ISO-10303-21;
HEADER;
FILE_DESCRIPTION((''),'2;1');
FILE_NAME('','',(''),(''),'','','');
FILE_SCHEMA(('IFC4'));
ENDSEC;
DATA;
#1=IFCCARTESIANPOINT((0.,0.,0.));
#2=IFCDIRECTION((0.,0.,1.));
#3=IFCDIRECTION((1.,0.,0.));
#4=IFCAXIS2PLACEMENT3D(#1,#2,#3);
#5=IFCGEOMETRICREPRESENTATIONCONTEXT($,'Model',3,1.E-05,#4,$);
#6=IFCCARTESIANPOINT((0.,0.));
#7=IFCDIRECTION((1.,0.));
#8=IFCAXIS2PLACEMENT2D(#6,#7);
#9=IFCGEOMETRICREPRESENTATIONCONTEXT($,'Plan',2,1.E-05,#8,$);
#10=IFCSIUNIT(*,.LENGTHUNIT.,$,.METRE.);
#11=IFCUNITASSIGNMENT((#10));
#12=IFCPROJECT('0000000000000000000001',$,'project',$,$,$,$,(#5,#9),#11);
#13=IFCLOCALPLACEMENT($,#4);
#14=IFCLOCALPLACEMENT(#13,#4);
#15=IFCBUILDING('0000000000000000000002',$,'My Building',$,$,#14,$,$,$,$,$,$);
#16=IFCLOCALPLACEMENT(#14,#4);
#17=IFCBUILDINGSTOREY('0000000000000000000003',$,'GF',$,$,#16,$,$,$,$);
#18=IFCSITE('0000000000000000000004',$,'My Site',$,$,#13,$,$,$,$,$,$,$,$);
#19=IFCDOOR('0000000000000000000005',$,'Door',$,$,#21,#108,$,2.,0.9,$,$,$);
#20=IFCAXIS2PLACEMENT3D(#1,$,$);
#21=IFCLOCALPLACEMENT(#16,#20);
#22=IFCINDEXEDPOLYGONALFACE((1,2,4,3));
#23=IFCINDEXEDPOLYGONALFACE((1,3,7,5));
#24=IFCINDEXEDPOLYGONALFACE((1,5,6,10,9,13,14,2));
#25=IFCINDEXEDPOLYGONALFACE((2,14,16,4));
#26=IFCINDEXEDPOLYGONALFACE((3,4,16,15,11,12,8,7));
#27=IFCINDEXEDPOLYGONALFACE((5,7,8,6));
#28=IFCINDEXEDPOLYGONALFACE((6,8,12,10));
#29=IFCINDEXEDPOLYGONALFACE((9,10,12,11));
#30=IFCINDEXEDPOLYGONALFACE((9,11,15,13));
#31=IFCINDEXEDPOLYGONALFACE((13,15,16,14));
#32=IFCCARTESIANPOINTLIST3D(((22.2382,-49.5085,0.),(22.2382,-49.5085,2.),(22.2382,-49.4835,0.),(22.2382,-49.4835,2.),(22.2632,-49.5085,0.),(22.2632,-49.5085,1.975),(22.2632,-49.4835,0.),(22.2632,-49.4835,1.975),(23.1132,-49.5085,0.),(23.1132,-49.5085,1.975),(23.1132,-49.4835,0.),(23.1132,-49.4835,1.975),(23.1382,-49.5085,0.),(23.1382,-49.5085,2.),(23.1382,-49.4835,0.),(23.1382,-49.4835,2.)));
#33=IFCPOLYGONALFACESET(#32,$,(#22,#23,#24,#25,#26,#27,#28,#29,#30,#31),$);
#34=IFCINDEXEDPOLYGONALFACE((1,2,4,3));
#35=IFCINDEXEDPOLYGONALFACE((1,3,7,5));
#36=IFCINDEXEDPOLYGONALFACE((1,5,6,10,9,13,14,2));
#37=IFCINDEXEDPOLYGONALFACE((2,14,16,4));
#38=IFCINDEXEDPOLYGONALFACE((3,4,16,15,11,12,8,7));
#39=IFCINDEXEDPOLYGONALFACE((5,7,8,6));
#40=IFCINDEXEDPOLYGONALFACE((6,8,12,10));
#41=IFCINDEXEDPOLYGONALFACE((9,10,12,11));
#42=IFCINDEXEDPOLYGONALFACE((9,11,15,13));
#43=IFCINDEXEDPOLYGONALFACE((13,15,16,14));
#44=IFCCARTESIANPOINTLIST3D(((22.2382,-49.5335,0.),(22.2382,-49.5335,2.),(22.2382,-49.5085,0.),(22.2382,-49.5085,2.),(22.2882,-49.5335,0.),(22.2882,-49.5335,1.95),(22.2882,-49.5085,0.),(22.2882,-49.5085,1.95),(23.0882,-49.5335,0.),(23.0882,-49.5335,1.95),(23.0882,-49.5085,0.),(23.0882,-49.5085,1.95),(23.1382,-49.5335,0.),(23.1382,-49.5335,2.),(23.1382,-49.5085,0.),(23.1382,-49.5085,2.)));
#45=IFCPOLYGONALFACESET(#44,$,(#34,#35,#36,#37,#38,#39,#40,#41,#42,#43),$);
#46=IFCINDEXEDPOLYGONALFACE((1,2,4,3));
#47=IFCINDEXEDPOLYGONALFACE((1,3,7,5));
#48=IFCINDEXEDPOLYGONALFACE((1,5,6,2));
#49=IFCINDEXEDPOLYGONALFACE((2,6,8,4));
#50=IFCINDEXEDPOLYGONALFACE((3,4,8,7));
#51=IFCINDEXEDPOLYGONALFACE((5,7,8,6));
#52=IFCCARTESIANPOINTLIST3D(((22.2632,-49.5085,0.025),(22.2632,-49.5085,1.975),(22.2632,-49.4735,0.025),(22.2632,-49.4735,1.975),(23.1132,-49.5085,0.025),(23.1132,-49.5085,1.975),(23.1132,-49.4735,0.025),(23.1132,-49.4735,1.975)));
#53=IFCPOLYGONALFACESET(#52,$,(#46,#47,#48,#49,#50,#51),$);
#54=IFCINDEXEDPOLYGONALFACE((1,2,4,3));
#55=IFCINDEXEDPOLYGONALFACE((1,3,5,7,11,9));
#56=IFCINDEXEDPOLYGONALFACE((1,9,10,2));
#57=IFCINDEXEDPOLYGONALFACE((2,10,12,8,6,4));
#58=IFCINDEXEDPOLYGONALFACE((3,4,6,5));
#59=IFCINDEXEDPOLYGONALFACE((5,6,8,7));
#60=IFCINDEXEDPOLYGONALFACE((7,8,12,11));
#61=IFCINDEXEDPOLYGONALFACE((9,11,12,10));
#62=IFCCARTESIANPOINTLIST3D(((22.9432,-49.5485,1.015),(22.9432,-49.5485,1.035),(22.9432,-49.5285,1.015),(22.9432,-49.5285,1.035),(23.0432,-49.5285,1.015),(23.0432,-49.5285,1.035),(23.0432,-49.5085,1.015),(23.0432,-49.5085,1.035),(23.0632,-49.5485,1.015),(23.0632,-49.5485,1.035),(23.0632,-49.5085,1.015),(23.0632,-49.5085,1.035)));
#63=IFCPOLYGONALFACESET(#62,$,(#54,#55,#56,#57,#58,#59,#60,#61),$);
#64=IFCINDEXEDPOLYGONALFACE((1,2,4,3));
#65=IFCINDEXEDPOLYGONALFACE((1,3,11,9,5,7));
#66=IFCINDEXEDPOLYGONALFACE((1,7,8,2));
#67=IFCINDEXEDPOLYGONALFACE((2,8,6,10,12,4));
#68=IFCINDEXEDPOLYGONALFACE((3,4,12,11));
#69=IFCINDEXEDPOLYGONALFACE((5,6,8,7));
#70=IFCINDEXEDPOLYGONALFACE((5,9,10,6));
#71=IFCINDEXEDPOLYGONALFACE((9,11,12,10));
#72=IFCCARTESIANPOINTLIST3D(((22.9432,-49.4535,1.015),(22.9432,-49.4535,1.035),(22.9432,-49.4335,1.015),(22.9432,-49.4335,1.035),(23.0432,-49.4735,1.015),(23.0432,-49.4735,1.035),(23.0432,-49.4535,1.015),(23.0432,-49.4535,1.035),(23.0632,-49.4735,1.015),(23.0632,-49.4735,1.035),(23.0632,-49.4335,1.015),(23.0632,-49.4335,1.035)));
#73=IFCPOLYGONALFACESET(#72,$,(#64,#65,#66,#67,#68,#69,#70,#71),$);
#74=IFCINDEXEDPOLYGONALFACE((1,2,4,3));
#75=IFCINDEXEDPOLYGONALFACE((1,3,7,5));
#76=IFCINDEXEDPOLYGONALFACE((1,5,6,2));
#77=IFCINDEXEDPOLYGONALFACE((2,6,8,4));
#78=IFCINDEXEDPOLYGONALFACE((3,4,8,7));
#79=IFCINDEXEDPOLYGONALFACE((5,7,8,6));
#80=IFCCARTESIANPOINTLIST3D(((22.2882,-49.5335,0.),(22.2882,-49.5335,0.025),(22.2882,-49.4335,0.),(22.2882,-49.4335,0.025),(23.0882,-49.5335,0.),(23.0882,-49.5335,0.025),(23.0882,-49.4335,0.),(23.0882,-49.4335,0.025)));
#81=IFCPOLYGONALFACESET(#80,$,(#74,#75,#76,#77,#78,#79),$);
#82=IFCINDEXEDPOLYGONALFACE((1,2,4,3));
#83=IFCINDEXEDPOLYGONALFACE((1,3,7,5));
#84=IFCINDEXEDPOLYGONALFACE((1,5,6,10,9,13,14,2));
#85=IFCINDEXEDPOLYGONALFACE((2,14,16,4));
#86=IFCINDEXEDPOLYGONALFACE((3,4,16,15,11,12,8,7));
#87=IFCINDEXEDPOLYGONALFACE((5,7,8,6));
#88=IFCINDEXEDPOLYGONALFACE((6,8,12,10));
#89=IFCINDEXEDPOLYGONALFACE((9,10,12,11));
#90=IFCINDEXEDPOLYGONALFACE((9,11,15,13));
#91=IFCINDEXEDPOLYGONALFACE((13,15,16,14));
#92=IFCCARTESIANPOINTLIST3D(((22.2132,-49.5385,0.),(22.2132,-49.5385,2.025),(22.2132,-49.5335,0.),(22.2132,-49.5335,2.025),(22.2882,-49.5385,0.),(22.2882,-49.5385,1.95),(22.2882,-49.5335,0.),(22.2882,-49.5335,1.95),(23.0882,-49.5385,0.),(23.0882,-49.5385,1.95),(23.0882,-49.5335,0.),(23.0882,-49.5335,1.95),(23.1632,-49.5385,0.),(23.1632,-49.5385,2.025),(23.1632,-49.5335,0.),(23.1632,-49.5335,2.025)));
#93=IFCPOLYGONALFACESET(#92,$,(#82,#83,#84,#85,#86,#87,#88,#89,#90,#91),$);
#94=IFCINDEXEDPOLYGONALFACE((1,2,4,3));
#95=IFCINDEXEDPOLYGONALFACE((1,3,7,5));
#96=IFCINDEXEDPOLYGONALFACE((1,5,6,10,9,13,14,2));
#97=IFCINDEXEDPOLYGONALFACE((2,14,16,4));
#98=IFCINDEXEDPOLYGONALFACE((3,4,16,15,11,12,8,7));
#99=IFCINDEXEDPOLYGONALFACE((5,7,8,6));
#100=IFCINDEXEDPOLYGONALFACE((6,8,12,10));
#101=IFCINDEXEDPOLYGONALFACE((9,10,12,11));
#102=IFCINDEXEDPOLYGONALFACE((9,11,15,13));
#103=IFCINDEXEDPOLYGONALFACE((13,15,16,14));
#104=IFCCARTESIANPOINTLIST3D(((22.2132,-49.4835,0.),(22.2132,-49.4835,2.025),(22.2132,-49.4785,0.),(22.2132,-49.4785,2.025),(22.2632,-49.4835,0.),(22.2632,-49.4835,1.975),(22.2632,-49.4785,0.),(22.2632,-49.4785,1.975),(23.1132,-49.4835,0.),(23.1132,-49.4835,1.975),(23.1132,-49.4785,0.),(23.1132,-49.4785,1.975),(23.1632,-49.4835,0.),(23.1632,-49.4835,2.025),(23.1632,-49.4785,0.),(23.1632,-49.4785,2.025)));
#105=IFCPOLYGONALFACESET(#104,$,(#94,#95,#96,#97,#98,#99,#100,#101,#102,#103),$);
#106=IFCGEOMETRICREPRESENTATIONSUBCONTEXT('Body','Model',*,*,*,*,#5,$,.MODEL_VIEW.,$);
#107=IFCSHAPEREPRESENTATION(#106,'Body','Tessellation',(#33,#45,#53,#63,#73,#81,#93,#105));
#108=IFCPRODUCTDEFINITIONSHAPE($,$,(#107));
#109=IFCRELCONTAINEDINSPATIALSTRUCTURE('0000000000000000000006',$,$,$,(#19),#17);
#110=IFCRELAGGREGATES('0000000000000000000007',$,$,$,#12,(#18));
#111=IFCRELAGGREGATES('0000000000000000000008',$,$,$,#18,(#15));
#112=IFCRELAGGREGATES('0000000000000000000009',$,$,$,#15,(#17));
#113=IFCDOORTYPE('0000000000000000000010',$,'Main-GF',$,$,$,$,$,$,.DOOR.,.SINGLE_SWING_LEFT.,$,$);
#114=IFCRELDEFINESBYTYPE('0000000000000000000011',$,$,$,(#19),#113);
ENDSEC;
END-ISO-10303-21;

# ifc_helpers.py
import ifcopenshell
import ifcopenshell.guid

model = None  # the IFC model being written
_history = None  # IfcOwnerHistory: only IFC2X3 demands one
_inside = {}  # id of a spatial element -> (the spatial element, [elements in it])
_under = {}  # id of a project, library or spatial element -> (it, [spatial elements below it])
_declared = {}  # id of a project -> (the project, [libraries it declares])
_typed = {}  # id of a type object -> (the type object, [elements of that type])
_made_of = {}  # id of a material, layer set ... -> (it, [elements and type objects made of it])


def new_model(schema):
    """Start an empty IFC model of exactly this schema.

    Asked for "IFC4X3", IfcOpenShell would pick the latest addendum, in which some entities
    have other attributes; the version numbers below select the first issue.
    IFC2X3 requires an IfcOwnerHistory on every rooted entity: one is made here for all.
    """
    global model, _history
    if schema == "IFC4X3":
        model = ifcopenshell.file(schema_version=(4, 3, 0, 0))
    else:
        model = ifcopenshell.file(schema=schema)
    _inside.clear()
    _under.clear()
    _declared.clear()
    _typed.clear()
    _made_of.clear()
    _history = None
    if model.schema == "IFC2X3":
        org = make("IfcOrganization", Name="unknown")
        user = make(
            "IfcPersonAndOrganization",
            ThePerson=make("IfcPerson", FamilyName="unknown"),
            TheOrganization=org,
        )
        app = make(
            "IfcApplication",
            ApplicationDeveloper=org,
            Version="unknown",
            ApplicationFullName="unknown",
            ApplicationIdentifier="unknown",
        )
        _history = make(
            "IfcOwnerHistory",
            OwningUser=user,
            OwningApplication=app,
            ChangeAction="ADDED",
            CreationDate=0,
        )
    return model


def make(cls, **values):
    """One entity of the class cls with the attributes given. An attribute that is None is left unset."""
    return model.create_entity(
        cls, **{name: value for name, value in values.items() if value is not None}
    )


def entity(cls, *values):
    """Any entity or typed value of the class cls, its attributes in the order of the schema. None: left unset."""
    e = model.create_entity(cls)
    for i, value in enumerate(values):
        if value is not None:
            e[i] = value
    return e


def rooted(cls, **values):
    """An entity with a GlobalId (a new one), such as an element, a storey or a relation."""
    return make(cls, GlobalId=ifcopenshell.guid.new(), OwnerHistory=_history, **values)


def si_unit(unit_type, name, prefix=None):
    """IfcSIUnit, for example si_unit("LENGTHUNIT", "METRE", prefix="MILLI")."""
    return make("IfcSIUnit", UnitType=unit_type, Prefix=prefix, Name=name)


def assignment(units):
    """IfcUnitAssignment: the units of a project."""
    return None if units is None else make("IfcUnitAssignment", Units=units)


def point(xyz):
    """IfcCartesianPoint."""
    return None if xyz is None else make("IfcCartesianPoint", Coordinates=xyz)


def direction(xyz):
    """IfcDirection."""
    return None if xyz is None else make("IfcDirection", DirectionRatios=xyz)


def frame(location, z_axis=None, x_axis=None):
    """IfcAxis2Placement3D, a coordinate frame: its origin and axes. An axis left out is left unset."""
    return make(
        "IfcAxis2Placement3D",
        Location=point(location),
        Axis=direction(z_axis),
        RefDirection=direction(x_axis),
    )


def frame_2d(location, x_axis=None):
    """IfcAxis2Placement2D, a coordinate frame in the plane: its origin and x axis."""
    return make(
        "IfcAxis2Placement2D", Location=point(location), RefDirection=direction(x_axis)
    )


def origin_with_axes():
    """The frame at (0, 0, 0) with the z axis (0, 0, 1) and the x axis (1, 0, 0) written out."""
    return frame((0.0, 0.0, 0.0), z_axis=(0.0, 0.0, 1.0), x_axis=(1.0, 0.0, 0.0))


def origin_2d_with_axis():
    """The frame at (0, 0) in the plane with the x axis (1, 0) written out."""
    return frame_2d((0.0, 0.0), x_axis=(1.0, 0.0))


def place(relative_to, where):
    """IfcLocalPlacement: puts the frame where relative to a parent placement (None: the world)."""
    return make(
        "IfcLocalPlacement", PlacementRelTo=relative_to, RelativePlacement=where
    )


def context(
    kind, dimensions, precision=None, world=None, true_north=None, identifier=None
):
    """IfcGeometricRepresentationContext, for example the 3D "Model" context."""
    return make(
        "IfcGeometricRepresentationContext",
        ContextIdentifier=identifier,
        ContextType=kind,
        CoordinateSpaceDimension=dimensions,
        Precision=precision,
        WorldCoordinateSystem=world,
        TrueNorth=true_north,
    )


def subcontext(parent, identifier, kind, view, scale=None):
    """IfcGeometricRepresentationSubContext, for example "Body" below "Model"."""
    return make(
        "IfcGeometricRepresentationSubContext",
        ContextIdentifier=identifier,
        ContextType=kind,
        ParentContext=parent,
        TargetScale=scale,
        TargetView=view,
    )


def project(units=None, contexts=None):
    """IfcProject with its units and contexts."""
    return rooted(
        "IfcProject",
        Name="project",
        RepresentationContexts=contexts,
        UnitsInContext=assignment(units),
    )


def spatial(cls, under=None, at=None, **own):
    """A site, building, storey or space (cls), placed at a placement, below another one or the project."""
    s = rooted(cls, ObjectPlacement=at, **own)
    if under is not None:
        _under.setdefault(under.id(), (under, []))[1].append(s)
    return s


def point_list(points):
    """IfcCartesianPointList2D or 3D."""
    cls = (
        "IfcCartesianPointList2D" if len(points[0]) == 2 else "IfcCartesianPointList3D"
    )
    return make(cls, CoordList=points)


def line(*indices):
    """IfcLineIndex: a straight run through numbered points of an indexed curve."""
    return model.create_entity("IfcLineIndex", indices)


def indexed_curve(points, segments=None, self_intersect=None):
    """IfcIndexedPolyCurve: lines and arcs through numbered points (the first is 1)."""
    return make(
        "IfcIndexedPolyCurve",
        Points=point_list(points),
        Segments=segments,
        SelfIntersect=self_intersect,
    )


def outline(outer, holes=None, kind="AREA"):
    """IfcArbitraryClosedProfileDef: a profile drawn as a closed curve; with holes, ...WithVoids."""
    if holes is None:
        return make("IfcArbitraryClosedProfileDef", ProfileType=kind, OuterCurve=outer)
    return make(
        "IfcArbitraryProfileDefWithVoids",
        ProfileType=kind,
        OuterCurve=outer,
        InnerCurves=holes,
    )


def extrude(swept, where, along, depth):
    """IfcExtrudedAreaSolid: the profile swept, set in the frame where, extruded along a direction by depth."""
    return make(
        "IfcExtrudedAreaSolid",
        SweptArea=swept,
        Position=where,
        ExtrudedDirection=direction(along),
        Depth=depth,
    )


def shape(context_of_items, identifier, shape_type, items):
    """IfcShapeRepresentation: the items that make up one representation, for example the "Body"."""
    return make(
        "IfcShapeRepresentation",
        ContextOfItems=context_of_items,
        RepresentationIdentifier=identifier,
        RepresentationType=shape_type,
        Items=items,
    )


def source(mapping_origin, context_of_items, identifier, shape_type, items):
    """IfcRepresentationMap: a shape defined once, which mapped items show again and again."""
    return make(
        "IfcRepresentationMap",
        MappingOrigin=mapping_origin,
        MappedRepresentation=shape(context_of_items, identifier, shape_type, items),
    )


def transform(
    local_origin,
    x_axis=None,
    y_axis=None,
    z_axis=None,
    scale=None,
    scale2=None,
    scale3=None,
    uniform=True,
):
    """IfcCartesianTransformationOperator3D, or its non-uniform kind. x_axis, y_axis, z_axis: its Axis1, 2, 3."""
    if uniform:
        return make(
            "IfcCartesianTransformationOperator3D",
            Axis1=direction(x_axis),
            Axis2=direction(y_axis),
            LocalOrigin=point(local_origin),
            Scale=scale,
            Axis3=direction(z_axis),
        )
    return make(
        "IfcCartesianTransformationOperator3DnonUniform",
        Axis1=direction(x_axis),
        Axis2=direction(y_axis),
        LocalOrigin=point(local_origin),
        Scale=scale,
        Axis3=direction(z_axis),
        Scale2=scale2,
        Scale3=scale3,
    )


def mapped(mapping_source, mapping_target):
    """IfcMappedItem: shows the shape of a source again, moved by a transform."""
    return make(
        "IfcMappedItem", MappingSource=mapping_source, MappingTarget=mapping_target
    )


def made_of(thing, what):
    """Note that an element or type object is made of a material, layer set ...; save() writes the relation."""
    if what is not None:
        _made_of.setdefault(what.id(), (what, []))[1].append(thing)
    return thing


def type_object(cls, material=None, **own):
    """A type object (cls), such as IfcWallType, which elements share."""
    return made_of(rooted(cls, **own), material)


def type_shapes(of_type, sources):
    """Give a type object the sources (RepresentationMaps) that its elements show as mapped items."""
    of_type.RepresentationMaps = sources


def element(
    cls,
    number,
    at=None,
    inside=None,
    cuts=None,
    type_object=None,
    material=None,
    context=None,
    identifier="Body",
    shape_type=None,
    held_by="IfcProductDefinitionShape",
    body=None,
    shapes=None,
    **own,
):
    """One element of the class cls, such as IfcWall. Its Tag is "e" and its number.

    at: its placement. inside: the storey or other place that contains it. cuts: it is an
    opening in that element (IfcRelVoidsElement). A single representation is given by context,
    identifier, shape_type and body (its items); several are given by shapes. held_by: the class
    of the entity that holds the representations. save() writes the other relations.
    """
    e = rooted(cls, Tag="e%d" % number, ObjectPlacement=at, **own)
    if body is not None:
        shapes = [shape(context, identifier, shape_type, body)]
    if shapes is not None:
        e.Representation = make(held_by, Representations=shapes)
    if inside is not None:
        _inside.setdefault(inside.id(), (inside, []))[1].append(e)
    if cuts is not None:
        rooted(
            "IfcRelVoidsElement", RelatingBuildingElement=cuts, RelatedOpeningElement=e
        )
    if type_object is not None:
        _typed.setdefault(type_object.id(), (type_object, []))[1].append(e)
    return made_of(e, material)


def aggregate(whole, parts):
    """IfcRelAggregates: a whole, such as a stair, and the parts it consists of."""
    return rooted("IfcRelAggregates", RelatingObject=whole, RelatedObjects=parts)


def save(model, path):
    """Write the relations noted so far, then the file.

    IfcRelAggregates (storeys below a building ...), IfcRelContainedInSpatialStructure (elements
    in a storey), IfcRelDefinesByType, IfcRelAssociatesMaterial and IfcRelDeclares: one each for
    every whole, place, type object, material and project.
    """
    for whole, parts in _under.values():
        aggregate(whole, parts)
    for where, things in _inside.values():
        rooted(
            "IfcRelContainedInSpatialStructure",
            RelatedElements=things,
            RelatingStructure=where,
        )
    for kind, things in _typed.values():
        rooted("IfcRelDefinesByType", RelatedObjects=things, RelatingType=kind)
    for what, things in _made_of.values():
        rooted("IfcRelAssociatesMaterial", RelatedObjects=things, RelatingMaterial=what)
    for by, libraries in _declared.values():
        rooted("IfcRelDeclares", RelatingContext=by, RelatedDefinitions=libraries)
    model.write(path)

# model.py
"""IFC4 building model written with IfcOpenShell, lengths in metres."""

from ifc_helpers import new_model, entity, si_unit, frame, origin_with_axes, origin_2d_with_axis, place, context, subcontext, project, spatial, line, indexed_curve, outline, extrude, shape, source, transform, mapped, type_object, type_shapes, element, save


model = new_model("IFC4")

# Units and contexts
model_context = context("Model", 3, precision=1e-05, world=origin_with_axes())
plan_context = context("Plan", 2, precision=1e-05, world=origin_2d_with_axis())
body_context_1 = subcontext(model_context, "Body", "Model", "MODEL_VIEW")
body_context_2 = subcontext(plan_context, "Body", "Plan", "PLAN_VIEW")
ifc_project = project(units=[si_unit("LENGTHUNIT", "METRE")], contexts=[model_context, plan_context])

# Site, building, storey
site_placement = place(None, origin_with_axes())
site = spatial("IfcSite", under=ifc_project, at=site_placement, Name="My Site")
building_placement = place(site_placement, origin_with_axes())
building = spatial("IfcBuilding", under=site, at=building_placement, Name="My Building")
storey_placement = place(building_placement, origin_with_axes())
storey = spatial("IfcBuildingStorey", under=building, at=storey_placement, Name="GF")

# Shared definitions
door_type_1 = type_object("IfcDoorType", Name="Main-GF", OperationType="SINGLE_SWING_LEFT", PredefinedType="DOOR")
shared_shape_1 = source(origin_with_axes(), body_context_1, "Body", "SweptSolid", [
    extrude(outline(indexed_curve([(0.0, 0.0), (0.0, 2.0), (0.9, 2.0), (0.9, 0.0), (0.875, 0.0), (0.875, 1.975), (0.025, 1.975), (0.025, 0.0)], segments=[line(1, 2, 3, 4, 5, 6, 7, 8, 1)])), frame((0.0, 0.025, 0.0), z_axis=(0.0, -1.0, 0.0), x_axis=(1.0, 0.0, 0.0)), (0.0, 0.0, -1.0), 0.025),
    extrude(outline(indexed_curve([(0.0, 0.0), (0.0, 2.0), (0.9, 2.0), (0.9, 0.0), (0.85, 0.0), (0.85, 1.95), (0.05, 1.95), (0.05, 0.0)], segments=[line(1, 2, 3, 4, 5, 6, 7, 8, 1)])), frame((0.0, 0.0, 0.0), z_axis=(0.0, -1.0, 0.0), x_axis=(1.0, 0.0, 0.0)), (0.0, 0.0, -1.0), 0.025),
    extrude(outline(indexed_curve([(0.0, 0.0), (0.85, 0.0), (0.85, 0.035), (0.0, 0.035)], segments=[line(1, 2, 3, 4, 1)])), frame((0.025, 0.025, 0.025), z_axis=(0.0, 0.0, 1.0), x_axis=(1.0, 0.0, 0.0)), (0.0, 0.0, 1.0), 1.95),
    extrude(outline(indexed_curve([(0.0, 0.0), (0.0, -0.04), (-0.12, -0.04), (-0.12, -0.02), (-0.02, -0.02), (-0.02, 0.0)], segments=[line(1, 2, 3, 4, 5, 6, 1)])), frame((0.825, 0.025, 1.015), z_axis=(0.0, 0.0, 1.0), x_axis=(1.0, 0.0, 0.0)), (0.0, 0.0, 1.0), 0.02),
    extrude(outline(indexed_curve([(0.0, 0.0), (0.0, 0.04), (-0.12, 0.04), (-0.12, 0.02), (-0.02, 0.02), (-0.02, 0.0)], segments=[line(1, 2, 3, 4, 5, 6, 1)])), frame((0.825, 0.06, 1.015), z_axis=(0.0, 0.0, 1.0), x_axis=(1.0, 0.0, 0.0)), (0.0, 0.0, 1.0), 0.02),
    extrude(outline(indexed_curve([(0.0, 0.0), (0.8, 0.0), (0.8, 0.1), (0.0, 0.1)], segments=[line(1, 2, 3, 4, 1)])), frame((0.05, 0.0, 0.0), z_axis=(0.0, 0.0, 1.0), x_axis=(1.0, 0.0, 0.0)), (0.0, 0.0, 1.0), 0.025),
    extrude(outline(indexed_curve([(0.0, 0.0), (0.0, 2.025), (0.95, 2.025), (0.95, 0.0), (0.875, 0.0), (0.875, 1.95), (0.075, 1.95), (0.075, 0.0)], segments=[line(1, 2, 3, 4, 5, 6, 7, 8, 1)])), frame((-0.025, -0.005, 0.0), z_axis=(0.0, -1.0, 0.0), x_axis=(1.0, 0.0, 0.0)), (0.0, 0.0, -1.0), 0.005),
    extrude(outline(indexed_curve([(0.0, 0.0), (0.0, 2.025), (0.95, 2.025), (0.95, 0.0), (0.9, 0.0), (0.9, 1.975), (0.05, 1.975), (0.05, 0.0)], segments=[line(1, 2, 3, 4, 5, 6, 7, 8, 1)])), frame((-0.025, 0.05, 0.0), z_axis=(0.0, -1.0, 0.0), x_axis=(1.0, 0.0, 0.0)), (0.0, 0.0, -1.0), 0.005),
])
shared_shape_2 = source(origin_with_axes(), body_context_2, "Body", "Curve2D", [
    entity("IfcIndexedPolyCurve", entity("IfcCartesianPointList2D", [[0.0, 0.0], [0.0, 0.05], [0.025, 0.05], [0.025, 0.025], [0.05, 0.025], [0.05, 0.0]]), [entity("IfcLineIndex", [1, 2, 3, 4, 5, 6, 1])]),
    entity("IfcIndexedPolyCurve", entity("IfcCartesianPointList2D", [[0.9, 0.0], [0.9, 0.05], [0.875, 0.05], [0.875, 0.025], [0.85, 0.025], [0.85, 0.0]]), [entity("IfcLineIndex", [1, 2, 3, 4, 5, 6, 1])]),
    entity("IfcTrimmedCurve", entity("IfcEllipse", entity("IfcAxis2Placement2D", entity("IfcCartesianPoint", [0.06, 0.05]), entity("IfcDirection", [1.0, 0.0])), 0.815, 0.85), [entity("IfcCartesianPoint", [0.875, 0.05])], [entity("IfcCartesianPoint", [0.06, 0.9])], True, "CARTESIAN"),
    entity("IfcIndexedPolyCurve", entity("IfcCartesianPointList2D", [[0.025, 0.05], [0.06, 0.05], [0.06, 0.9], [0.025, 0.9]]), [entity("IfcLineIndex", [1, 2, 3, 4, 1])]),
])
type_shapes(door_type_1, [shared_shape_1, shared_shape_2])

# Door
door_1_placement = place(storey_placement, frame((22.2382, -49.5335, 0.0), z_axis=(0.0, 0.0, 1.0), x_axis=(1.0, 0.0, 0.0)))
element("IfcDoor", 1, at=door_1_placement, inside=storey, type_object=door_type_1, Name="Door", OverallHeight=2.0, OverallWidth=0.9, shapes=[
    shape(body_context_1, "Body", "MappedRepresentation", [mapped(shared_shape_1, transform((0.0, 0.0, 0.0), x_axis=(1.0, 0.0, 0.0), y_axis=(0.0, 1.0, 0.0), z_axis=(0.0, 0.0, 1.0), scale=1.0))]),
    shape(body_context_2, "Body", "MappedRepresentation", [mapped(shared_shape_2, transform((0.0, 0.0, 0.0), x_axis=(1.0, 0.0, 0.0), y_axis=(0.0, 1.0, 0.0), z_axis=(0.0, 0.0, 1.0), scale=1.0))]),
])

save(model, "model.ifc")
